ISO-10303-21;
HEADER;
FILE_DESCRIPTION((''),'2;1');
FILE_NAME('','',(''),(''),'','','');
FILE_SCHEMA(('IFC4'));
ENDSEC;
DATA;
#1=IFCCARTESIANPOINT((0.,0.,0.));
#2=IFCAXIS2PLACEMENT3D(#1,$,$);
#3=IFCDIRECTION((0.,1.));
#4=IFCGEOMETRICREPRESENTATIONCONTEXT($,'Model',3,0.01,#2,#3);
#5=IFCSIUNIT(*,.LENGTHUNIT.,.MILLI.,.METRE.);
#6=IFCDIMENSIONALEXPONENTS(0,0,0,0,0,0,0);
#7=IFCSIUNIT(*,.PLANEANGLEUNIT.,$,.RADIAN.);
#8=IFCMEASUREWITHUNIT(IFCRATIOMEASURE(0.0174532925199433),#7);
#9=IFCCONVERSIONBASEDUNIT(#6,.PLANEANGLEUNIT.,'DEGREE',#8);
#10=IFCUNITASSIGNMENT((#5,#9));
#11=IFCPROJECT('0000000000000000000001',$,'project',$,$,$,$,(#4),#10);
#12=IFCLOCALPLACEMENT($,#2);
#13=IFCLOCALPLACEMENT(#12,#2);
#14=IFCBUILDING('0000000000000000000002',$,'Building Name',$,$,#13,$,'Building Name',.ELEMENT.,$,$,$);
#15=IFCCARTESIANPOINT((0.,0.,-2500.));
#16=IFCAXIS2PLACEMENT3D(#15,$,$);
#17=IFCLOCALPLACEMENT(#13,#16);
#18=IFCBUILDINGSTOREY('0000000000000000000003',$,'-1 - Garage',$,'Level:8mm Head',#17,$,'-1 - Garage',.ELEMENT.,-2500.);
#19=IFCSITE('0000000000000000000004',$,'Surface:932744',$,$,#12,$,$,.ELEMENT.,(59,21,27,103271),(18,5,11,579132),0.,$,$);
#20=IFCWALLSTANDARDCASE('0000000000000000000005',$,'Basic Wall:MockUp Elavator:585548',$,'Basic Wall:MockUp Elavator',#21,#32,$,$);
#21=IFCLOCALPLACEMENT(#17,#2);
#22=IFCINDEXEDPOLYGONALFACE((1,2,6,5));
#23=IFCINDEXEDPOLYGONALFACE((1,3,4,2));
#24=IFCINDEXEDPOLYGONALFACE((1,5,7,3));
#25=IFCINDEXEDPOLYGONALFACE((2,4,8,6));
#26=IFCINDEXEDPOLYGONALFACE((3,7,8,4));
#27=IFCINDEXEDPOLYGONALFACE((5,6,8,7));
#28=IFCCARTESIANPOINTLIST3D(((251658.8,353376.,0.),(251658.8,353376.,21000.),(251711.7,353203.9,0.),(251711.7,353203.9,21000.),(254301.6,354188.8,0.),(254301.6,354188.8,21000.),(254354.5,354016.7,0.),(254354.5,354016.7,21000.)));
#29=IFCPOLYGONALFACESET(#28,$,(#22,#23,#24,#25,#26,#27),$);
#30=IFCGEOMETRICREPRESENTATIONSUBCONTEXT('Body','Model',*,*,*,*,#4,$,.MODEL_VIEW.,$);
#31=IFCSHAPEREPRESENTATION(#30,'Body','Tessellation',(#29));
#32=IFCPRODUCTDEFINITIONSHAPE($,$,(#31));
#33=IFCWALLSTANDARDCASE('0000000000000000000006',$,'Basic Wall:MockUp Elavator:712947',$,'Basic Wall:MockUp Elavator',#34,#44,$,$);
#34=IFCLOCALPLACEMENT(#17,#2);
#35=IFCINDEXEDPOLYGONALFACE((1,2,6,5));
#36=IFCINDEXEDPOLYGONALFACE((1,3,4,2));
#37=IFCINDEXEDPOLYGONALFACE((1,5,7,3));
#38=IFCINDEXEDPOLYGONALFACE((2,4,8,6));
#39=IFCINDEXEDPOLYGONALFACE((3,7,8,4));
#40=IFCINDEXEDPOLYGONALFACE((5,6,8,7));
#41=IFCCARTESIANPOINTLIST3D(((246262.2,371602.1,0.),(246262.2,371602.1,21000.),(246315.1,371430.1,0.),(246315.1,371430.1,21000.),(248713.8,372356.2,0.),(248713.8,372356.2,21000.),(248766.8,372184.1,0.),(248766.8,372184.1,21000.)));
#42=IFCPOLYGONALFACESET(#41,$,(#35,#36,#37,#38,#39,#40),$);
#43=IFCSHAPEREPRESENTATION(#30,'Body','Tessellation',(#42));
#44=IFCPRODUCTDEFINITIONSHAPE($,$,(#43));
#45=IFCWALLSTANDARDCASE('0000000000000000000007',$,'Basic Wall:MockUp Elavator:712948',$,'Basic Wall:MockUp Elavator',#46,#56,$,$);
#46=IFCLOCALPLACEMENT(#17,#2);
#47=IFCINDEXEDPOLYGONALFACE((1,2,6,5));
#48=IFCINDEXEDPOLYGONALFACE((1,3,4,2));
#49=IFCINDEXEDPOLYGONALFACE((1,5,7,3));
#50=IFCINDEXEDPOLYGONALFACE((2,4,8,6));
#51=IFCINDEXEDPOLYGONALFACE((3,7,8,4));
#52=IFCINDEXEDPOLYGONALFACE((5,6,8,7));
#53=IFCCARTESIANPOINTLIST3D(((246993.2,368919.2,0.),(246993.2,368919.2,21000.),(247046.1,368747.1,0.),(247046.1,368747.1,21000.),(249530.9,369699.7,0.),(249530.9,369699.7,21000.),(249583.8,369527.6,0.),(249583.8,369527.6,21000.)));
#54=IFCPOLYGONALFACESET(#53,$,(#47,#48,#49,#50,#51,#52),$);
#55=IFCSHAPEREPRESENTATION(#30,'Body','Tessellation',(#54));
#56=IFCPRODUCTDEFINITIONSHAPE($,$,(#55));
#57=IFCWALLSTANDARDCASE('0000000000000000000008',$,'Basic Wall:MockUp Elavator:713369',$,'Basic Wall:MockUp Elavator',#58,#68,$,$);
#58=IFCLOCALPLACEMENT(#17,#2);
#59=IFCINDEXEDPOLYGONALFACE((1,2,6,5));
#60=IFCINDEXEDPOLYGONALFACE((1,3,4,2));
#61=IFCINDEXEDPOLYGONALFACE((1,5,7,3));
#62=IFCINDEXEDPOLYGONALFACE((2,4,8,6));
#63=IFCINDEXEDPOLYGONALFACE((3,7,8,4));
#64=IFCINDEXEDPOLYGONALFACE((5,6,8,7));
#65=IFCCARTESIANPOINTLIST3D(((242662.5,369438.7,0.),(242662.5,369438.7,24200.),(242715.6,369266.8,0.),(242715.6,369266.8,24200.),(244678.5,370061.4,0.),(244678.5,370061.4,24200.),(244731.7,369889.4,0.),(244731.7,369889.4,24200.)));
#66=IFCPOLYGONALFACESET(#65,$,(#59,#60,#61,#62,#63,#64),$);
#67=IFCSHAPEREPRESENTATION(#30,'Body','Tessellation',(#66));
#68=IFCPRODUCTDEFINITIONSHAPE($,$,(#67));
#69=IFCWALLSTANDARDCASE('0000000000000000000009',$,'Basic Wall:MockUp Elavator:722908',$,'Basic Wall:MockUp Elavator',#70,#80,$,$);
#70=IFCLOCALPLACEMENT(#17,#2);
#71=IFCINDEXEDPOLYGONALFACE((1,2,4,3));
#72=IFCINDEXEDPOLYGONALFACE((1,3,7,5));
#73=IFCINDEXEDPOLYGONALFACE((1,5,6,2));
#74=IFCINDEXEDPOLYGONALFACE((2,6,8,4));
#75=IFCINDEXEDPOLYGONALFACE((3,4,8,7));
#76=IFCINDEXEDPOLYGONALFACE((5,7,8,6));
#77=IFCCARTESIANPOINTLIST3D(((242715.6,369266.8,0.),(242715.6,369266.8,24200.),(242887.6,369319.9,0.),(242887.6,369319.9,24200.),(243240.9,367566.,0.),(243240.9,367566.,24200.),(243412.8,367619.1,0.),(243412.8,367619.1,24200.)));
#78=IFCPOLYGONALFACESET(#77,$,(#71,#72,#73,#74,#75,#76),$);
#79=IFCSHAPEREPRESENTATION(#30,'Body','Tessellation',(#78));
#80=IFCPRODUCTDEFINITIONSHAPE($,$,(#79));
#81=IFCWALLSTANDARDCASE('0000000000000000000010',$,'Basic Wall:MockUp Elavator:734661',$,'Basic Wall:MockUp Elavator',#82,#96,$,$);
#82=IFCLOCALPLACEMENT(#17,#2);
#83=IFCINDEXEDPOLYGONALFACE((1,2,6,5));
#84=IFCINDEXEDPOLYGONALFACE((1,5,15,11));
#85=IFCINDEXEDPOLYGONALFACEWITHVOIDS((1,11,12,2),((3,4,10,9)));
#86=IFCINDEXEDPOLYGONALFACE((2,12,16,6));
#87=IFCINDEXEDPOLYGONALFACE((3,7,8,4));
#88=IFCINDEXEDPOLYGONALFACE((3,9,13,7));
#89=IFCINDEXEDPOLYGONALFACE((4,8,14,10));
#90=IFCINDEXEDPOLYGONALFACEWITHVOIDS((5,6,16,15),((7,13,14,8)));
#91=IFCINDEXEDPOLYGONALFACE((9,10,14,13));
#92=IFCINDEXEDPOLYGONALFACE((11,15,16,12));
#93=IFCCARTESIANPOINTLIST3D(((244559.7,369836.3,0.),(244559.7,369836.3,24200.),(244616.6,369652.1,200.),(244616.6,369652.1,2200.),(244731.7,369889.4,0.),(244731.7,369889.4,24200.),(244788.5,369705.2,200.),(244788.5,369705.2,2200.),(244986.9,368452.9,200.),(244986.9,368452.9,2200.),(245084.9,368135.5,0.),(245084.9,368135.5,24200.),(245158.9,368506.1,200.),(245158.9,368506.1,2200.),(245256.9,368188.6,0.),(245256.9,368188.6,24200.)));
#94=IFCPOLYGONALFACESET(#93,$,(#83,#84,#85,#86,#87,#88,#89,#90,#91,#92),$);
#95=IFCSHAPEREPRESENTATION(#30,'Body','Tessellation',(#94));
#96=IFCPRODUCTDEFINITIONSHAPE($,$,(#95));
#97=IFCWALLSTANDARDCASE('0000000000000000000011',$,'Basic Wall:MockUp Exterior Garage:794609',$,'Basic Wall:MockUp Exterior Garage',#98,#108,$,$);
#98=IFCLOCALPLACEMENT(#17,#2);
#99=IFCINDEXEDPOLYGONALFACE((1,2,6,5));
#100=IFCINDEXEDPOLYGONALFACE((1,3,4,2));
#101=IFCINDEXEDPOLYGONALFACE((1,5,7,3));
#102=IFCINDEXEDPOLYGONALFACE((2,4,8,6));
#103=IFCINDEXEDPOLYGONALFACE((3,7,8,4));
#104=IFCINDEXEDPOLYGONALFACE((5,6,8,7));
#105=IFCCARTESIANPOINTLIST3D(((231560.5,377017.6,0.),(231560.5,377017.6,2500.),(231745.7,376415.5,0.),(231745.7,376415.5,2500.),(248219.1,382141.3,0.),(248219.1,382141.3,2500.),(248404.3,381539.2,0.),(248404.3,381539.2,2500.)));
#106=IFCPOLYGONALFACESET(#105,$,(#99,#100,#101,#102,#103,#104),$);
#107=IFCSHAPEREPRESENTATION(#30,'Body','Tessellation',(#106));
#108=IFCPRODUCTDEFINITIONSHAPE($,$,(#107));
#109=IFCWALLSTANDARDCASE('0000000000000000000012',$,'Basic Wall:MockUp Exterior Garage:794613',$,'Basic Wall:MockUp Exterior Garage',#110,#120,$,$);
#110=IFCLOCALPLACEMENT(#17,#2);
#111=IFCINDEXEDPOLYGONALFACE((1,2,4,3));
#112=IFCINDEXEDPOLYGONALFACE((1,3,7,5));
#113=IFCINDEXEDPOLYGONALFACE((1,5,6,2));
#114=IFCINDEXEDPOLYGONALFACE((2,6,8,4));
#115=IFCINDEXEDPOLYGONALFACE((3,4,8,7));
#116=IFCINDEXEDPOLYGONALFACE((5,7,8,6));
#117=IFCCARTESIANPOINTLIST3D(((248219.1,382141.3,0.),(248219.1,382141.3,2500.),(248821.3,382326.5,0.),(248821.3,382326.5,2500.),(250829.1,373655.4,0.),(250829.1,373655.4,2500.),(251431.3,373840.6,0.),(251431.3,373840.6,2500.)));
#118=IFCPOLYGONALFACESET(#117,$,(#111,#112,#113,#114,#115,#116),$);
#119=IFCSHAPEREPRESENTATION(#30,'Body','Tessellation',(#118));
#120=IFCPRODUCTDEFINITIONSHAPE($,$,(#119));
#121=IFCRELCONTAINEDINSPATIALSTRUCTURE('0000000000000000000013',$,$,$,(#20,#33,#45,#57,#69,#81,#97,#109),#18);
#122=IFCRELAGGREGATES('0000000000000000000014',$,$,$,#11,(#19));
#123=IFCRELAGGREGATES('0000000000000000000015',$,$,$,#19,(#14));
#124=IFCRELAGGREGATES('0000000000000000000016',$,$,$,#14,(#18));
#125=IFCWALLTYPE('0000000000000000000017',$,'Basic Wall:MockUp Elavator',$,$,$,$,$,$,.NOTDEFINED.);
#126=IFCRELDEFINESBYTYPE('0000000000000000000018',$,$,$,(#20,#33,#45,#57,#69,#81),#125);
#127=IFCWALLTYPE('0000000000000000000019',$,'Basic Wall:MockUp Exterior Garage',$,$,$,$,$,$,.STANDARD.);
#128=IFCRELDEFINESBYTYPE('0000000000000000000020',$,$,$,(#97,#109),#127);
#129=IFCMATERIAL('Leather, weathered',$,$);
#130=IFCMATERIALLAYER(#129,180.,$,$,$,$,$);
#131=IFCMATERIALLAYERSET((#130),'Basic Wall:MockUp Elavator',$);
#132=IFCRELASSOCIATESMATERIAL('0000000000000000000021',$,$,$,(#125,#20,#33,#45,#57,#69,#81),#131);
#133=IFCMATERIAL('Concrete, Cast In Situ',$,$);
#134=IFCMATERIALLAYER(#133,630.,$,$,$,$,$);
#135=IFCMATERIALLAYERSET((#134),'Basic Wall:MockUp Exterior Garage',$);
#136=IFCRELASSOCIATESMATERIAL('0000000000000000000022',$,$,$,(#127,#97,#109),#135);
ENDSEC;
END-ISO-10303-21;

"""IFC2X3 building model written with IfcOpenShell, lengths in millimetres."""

from ifc_helpers import new_model, entity, si_unit, converted_unit, direction, frame, frame_2d, origin, place, context, subcontext, project, spatial, rectangle, extrude, material, layer, layer_set, layer_usage, type_object, element, save


model = new_model("IFC2X3")

# Units and contexts
model_context = context("Model", 3, precision=0.01, world=origin(), true_north=direction((0.0, 1.0)))
body_context = subcontext(model_context, "Body", "Model", "MODEL_VIEW")
ifc_project = project(units=[si_unit("LENGTHUNIT", "METRE", prefix="MILLI"), converted_unit("PLANEANGLEUNIT", "DEGREE", entity("IfcRatioMeasure", 0.0174532925199433), si_unit("PLANEANGLEUNIT", "RADIAN"), dimensions=[0, 0, 0, 0, 0, 0, 0])], contexts=[model_context])

# Site, building, storey
site_placement = place(None, origin())
site = spatial("IfcSite", under=ifc_project, at=site_placement, Name="Surface:932744", CompositionType="ELEMENT", RefLatitude=(59, 21, 27, 103271), RefLongitude=(18, 5, 11, 579132), RefElevation=0.0)
building_placement = place(site_placement, origin())
building = spatial("IfcBuilding", under=site, at=building_placement, Name="Building Name", LongName="Building Name", CompositionType="ELEMENT")
storey_placement = place(building_placement, frame((0.0, 0.0, -2500.0)))
storey = spatial("IfcBuildingStorey", under=building, at=storey_placement, Name="-1 - Garage", ObjectType="Level:8mm Head", LongName="-1 - Garage", CompositionType="ELEMENT", Elevation=-2500.0)

# Shared definitions
ifc_material_1 = material(Name="Leather, weathered")

# Walls
ifc_layer_1 = layer(ifc_material_1, 180.0)
ifc_layer_set_1 = layer_set([ifc_layer_1], Name="Basic Wall:MockUp Elavator")
ifc_layer_usage_1 = layer_usage(ifc_layer_set_1, "AXIS2", "NEGATIVE", 90.0)
wall_type_1 = type_object("IfcWallType", Name="Basic Wall:MockUp Elavator", PredefinedType="NOTDEFINED", material=ifc_layer_set_1)
wall_1_placement = place(storey_placement, frame((254328.1, 354102.8, 0.0), z_axis=(0.0, 0.0, 1.0), x_axis=(-0.955818, -0.293958, 0.0)))
element("IfcWallStandardCase", 1, at=wall_1_placement, inside=storey, type_object=wall_type_1, material=ifc_layer_usage_1, Name="Basic Wall:MockUp Elavator:585548", ObjectType="Basic Wall:MockUp Elavator", context=body_context, shape_type="SweptSolid", body=[
    extrude(rectangle(XDim=2765.0, YDim=180.0, at=frame_2d((1382.5, 0.0), x_axis=(-1.0, 0.0))), origin(), (0.0, 0.0, 1.0), 21000.0),
])
ifc_layer_usage_2 = layer_usage(ifc_layer_set_1, "AXIS2", "NEGATIVE", 90.0)
wall_2_placement = place(storey_placement, frame((248740.3, 372270.1, 0.0), z_axis=(0.0, 0.0, 1.0), x_axis=(-0.955811, -0.29398, 0.0)))
element("IfcWallStandardCase", 2, at=wall_2_placement, inside=storey, type_object=wall_type_1, material=ifc_layer_usage_2, Name="Basic Wall:MockUp Elavator:712947", ObjectType="Basic Wall:MockUp Elavator", context=body_context, shape_type="SweptSolid", body=[
    extrude(rectangle(XDim=2565.0, YDim=180.0, at=frame_2d((1282.5, 0.0), x_axis=(-1.0, 0.0))), origin(), (0.0, 0.0, 1.0), 21000.0),
])
ifc_layer_usage_3 = layer_usage(ifc_layer_set_1, "AXIS2", "NEGATIVE", 90.0)
wall_3_placement = place(storey_placement, frame((249557.4, 369613.6, 0.0), z_axis=(0.0, 0.0, 1.0), x_axis=(-0.955811, -0.29398, 0.0)))
element("IfcWallStandardCase", 3, at=wall_3_placement, inside=storey, type_object=wall_type_1, material=ifc_layer_usage_3, Name="Basic Wall:MockUp Elavator:712948", ObjectType="Basic Wall:MockUp Elavator", context=body_context, shape_type="SweptSolid", body=[
    extrude(rectangle(XDim=2655.0, YDim=180.0, at=frame_2d((1327.5, 0.0), x_axis=(-1.0, 0.0))), origin(), (0.0, 0.0, 1.0), 21000.0),
])
ifc_layer_usage_4 = layer_usage(ifc_layer_set_1, "AXIS2", "NEGATIVE", 90.0)
wall_4_placement = place(storey_placement, frame((242689.1, 369352.7, 0.0), z_axis=(0.0, 0.0, 1.0), x_axis=(0.955473, 0.29508, 0.0)))
element("IfcWallStandardCase", 4, at=wall_4_placement, inside=storey, type_object=wall_type_1, material=ifc_layer_usage_4, Name="Basic Wall:MockUp Elavator:713369", ObjectType="Basic Wall:MockUp Elavator", context=body_context, shape_type="SweptSolid", body=[
    extrude(rectangle(XDim=2110.0, YDim=180.0, at=frame_2d((1055.0, 0.0), x_axis=(-1.0, 0.0))), origin(), (0.0, 0.0, 1.0), 24200.0),
])
ifc_layer_usage_5 = layer_usage(ifc_layer_set_1, "AXIS2", "NEGATIVE", 90.0)
wall_5_placement = place(storey_placement, frame((242801.6, 369293.3, 0.0), z_axis=(0.0, 0.0, 1.0), x_axis=(0.29508, -0.955473, 0.0)))
element("IfcWallStandardCase", 5, at=wall_5_placement, inside=storey, type_object=wall_type_1, material=ifc_layer_usage_5, Name="Basic Wall:MockUp Elavator:722908", ObjectType="Basic Wall:MockUp Elavator", context=body_context, shape_type="SweptSolid", body=[
    extrude(rectangle(XDim=1780.0, YDim=180.0, at=frame_2d((890.0, 0.0), x_axis=(-1.0, 0.0))), origin(), (0.0, 0.0, 1.0), 24200.0),
])

# Wall, opening
ifc_layer_usage_6 = layer_usage(ifc_layer_set_1, "AXIS2", "NEGATIVE", 90.0)
wall_6_placement = place(storey_placement, frame((244645.7, 369862.8, 0.0), z_axis=(0.0, 0.0, 1.0), x_axis=(0.29508, -0.955473, 0.0)))
wall_6 = element("IfcWallStandardCase", 6, at=wall_6_placement, inside=storey, type_object=wall_type_1, material=ifc_layer_usage_6, Name="Basic Wall:MockUp Elavator:734661", ObjectType="Basic Wall:MockUp Elavator", context=body_context, shape_type="SweptSolid", body=[
    extrude(rectangle(XDim=1780.0, YDim=180.0, at=frame_2d((890.0, 0.0), x_axis=(-1.0, 0.0))), origin(), (0.0, 0.0, 1.0), 24200.0),
])
opening_1_placement = place(wall_6_placement, origin())
element("IfcOpeningElement", 7, at=opening_1_placement, cuts=wall_6, ObjectType="Opening", context=body_context, shape_type="SweptSolid", body=[
    extrude(rectangle(XDim=2000.0, YDim=1255.0, at=frame_2d((0.0, 0.0), x_axis=(1.0, 0.0))), frame((820.3, -1614.0, 1200.0), z_axis=(0.0, 1.0, 0.0), x_axis=(0.0, 0.0, 1.0)), (0.0, 0.0, 1.0), 3048.0),
])

# Wall
ifc_material_2 = material(Name="Concrete, Cast In Situ")
ifc_layer_2 = layer(ifc_material_2, 630.0)
ifc_layer_set_2 = layer_set([ifc_layer_2], Name="Basic Wall:MockUp Exterior Garage")
ifc_layer_usage_7 = layer_usage(ifc_layer_set_2, "AXIS2", "NEGATIVE", 315.0)
wall_type_2 = type_object("IfcWallType", Name="Basic Wall:MockUp Exterior Garage", PredefinedType="STANDARD", material=ifc_layer_set_2)
wall_7_placement = place(storey_placement, frame((248311.7, 381840.3, 0.0), z_axis=(0.0, 0.0, 1.0), x_axis=(-0.955811, -0.29398, 0.0)))
element("IfcWallStandardCase", 8, at=wall_7_placement, inside=storey, type_object=wall_type_2, material=ifc_layer_usage_7, Name="Basic Wall:MockUp Exterior Garage:794609", ObjectType="Basic Wall:MockUp Exterior Garage", context=body_context, shape_type="SweptSolid", body=[
    extrude(rectangle(XDim=17428.8, YDim=630.0, at=frame_2d((8714.4, 0.0), x_axis=(-1.0, 0.0))), origin(), (0.0, 0.0, 1.0), 2500.0),
])

# Wall
ifc_layer_usage_8 = layer_usage(ifc_layer_set_2, "AXIS2", "NEGATIVE", 315.0)
wall_8_placement = place(storey_placement, frame((251130.2, 373748.0, 0.0), z_axis=(0.0, 0.0, 1.0), x_axis=(-0.29398, 0.955811, 0.0)))
element("IfcWallStandardCase", 9, at=wall_8_placement, inside=storey, type_object=wall_type_2, material=ifc_layer_usage_8, Name="Basic Wall:MockUp Exterior Garage:794613", ObjectType="Basic Wall:MockUp Exterior Garage", context=body_context, shape_type="SweptSolid", body=[
    extrude(rectangle(XDim=8878.2, YDim=630.0, at=frame_2d((4439.1, 0.0), x_axis=(-1.0, 0.0))), origin(), (0.0, 0.0, 1.0), 2500.0),
])

save(model, "model.ifc")
